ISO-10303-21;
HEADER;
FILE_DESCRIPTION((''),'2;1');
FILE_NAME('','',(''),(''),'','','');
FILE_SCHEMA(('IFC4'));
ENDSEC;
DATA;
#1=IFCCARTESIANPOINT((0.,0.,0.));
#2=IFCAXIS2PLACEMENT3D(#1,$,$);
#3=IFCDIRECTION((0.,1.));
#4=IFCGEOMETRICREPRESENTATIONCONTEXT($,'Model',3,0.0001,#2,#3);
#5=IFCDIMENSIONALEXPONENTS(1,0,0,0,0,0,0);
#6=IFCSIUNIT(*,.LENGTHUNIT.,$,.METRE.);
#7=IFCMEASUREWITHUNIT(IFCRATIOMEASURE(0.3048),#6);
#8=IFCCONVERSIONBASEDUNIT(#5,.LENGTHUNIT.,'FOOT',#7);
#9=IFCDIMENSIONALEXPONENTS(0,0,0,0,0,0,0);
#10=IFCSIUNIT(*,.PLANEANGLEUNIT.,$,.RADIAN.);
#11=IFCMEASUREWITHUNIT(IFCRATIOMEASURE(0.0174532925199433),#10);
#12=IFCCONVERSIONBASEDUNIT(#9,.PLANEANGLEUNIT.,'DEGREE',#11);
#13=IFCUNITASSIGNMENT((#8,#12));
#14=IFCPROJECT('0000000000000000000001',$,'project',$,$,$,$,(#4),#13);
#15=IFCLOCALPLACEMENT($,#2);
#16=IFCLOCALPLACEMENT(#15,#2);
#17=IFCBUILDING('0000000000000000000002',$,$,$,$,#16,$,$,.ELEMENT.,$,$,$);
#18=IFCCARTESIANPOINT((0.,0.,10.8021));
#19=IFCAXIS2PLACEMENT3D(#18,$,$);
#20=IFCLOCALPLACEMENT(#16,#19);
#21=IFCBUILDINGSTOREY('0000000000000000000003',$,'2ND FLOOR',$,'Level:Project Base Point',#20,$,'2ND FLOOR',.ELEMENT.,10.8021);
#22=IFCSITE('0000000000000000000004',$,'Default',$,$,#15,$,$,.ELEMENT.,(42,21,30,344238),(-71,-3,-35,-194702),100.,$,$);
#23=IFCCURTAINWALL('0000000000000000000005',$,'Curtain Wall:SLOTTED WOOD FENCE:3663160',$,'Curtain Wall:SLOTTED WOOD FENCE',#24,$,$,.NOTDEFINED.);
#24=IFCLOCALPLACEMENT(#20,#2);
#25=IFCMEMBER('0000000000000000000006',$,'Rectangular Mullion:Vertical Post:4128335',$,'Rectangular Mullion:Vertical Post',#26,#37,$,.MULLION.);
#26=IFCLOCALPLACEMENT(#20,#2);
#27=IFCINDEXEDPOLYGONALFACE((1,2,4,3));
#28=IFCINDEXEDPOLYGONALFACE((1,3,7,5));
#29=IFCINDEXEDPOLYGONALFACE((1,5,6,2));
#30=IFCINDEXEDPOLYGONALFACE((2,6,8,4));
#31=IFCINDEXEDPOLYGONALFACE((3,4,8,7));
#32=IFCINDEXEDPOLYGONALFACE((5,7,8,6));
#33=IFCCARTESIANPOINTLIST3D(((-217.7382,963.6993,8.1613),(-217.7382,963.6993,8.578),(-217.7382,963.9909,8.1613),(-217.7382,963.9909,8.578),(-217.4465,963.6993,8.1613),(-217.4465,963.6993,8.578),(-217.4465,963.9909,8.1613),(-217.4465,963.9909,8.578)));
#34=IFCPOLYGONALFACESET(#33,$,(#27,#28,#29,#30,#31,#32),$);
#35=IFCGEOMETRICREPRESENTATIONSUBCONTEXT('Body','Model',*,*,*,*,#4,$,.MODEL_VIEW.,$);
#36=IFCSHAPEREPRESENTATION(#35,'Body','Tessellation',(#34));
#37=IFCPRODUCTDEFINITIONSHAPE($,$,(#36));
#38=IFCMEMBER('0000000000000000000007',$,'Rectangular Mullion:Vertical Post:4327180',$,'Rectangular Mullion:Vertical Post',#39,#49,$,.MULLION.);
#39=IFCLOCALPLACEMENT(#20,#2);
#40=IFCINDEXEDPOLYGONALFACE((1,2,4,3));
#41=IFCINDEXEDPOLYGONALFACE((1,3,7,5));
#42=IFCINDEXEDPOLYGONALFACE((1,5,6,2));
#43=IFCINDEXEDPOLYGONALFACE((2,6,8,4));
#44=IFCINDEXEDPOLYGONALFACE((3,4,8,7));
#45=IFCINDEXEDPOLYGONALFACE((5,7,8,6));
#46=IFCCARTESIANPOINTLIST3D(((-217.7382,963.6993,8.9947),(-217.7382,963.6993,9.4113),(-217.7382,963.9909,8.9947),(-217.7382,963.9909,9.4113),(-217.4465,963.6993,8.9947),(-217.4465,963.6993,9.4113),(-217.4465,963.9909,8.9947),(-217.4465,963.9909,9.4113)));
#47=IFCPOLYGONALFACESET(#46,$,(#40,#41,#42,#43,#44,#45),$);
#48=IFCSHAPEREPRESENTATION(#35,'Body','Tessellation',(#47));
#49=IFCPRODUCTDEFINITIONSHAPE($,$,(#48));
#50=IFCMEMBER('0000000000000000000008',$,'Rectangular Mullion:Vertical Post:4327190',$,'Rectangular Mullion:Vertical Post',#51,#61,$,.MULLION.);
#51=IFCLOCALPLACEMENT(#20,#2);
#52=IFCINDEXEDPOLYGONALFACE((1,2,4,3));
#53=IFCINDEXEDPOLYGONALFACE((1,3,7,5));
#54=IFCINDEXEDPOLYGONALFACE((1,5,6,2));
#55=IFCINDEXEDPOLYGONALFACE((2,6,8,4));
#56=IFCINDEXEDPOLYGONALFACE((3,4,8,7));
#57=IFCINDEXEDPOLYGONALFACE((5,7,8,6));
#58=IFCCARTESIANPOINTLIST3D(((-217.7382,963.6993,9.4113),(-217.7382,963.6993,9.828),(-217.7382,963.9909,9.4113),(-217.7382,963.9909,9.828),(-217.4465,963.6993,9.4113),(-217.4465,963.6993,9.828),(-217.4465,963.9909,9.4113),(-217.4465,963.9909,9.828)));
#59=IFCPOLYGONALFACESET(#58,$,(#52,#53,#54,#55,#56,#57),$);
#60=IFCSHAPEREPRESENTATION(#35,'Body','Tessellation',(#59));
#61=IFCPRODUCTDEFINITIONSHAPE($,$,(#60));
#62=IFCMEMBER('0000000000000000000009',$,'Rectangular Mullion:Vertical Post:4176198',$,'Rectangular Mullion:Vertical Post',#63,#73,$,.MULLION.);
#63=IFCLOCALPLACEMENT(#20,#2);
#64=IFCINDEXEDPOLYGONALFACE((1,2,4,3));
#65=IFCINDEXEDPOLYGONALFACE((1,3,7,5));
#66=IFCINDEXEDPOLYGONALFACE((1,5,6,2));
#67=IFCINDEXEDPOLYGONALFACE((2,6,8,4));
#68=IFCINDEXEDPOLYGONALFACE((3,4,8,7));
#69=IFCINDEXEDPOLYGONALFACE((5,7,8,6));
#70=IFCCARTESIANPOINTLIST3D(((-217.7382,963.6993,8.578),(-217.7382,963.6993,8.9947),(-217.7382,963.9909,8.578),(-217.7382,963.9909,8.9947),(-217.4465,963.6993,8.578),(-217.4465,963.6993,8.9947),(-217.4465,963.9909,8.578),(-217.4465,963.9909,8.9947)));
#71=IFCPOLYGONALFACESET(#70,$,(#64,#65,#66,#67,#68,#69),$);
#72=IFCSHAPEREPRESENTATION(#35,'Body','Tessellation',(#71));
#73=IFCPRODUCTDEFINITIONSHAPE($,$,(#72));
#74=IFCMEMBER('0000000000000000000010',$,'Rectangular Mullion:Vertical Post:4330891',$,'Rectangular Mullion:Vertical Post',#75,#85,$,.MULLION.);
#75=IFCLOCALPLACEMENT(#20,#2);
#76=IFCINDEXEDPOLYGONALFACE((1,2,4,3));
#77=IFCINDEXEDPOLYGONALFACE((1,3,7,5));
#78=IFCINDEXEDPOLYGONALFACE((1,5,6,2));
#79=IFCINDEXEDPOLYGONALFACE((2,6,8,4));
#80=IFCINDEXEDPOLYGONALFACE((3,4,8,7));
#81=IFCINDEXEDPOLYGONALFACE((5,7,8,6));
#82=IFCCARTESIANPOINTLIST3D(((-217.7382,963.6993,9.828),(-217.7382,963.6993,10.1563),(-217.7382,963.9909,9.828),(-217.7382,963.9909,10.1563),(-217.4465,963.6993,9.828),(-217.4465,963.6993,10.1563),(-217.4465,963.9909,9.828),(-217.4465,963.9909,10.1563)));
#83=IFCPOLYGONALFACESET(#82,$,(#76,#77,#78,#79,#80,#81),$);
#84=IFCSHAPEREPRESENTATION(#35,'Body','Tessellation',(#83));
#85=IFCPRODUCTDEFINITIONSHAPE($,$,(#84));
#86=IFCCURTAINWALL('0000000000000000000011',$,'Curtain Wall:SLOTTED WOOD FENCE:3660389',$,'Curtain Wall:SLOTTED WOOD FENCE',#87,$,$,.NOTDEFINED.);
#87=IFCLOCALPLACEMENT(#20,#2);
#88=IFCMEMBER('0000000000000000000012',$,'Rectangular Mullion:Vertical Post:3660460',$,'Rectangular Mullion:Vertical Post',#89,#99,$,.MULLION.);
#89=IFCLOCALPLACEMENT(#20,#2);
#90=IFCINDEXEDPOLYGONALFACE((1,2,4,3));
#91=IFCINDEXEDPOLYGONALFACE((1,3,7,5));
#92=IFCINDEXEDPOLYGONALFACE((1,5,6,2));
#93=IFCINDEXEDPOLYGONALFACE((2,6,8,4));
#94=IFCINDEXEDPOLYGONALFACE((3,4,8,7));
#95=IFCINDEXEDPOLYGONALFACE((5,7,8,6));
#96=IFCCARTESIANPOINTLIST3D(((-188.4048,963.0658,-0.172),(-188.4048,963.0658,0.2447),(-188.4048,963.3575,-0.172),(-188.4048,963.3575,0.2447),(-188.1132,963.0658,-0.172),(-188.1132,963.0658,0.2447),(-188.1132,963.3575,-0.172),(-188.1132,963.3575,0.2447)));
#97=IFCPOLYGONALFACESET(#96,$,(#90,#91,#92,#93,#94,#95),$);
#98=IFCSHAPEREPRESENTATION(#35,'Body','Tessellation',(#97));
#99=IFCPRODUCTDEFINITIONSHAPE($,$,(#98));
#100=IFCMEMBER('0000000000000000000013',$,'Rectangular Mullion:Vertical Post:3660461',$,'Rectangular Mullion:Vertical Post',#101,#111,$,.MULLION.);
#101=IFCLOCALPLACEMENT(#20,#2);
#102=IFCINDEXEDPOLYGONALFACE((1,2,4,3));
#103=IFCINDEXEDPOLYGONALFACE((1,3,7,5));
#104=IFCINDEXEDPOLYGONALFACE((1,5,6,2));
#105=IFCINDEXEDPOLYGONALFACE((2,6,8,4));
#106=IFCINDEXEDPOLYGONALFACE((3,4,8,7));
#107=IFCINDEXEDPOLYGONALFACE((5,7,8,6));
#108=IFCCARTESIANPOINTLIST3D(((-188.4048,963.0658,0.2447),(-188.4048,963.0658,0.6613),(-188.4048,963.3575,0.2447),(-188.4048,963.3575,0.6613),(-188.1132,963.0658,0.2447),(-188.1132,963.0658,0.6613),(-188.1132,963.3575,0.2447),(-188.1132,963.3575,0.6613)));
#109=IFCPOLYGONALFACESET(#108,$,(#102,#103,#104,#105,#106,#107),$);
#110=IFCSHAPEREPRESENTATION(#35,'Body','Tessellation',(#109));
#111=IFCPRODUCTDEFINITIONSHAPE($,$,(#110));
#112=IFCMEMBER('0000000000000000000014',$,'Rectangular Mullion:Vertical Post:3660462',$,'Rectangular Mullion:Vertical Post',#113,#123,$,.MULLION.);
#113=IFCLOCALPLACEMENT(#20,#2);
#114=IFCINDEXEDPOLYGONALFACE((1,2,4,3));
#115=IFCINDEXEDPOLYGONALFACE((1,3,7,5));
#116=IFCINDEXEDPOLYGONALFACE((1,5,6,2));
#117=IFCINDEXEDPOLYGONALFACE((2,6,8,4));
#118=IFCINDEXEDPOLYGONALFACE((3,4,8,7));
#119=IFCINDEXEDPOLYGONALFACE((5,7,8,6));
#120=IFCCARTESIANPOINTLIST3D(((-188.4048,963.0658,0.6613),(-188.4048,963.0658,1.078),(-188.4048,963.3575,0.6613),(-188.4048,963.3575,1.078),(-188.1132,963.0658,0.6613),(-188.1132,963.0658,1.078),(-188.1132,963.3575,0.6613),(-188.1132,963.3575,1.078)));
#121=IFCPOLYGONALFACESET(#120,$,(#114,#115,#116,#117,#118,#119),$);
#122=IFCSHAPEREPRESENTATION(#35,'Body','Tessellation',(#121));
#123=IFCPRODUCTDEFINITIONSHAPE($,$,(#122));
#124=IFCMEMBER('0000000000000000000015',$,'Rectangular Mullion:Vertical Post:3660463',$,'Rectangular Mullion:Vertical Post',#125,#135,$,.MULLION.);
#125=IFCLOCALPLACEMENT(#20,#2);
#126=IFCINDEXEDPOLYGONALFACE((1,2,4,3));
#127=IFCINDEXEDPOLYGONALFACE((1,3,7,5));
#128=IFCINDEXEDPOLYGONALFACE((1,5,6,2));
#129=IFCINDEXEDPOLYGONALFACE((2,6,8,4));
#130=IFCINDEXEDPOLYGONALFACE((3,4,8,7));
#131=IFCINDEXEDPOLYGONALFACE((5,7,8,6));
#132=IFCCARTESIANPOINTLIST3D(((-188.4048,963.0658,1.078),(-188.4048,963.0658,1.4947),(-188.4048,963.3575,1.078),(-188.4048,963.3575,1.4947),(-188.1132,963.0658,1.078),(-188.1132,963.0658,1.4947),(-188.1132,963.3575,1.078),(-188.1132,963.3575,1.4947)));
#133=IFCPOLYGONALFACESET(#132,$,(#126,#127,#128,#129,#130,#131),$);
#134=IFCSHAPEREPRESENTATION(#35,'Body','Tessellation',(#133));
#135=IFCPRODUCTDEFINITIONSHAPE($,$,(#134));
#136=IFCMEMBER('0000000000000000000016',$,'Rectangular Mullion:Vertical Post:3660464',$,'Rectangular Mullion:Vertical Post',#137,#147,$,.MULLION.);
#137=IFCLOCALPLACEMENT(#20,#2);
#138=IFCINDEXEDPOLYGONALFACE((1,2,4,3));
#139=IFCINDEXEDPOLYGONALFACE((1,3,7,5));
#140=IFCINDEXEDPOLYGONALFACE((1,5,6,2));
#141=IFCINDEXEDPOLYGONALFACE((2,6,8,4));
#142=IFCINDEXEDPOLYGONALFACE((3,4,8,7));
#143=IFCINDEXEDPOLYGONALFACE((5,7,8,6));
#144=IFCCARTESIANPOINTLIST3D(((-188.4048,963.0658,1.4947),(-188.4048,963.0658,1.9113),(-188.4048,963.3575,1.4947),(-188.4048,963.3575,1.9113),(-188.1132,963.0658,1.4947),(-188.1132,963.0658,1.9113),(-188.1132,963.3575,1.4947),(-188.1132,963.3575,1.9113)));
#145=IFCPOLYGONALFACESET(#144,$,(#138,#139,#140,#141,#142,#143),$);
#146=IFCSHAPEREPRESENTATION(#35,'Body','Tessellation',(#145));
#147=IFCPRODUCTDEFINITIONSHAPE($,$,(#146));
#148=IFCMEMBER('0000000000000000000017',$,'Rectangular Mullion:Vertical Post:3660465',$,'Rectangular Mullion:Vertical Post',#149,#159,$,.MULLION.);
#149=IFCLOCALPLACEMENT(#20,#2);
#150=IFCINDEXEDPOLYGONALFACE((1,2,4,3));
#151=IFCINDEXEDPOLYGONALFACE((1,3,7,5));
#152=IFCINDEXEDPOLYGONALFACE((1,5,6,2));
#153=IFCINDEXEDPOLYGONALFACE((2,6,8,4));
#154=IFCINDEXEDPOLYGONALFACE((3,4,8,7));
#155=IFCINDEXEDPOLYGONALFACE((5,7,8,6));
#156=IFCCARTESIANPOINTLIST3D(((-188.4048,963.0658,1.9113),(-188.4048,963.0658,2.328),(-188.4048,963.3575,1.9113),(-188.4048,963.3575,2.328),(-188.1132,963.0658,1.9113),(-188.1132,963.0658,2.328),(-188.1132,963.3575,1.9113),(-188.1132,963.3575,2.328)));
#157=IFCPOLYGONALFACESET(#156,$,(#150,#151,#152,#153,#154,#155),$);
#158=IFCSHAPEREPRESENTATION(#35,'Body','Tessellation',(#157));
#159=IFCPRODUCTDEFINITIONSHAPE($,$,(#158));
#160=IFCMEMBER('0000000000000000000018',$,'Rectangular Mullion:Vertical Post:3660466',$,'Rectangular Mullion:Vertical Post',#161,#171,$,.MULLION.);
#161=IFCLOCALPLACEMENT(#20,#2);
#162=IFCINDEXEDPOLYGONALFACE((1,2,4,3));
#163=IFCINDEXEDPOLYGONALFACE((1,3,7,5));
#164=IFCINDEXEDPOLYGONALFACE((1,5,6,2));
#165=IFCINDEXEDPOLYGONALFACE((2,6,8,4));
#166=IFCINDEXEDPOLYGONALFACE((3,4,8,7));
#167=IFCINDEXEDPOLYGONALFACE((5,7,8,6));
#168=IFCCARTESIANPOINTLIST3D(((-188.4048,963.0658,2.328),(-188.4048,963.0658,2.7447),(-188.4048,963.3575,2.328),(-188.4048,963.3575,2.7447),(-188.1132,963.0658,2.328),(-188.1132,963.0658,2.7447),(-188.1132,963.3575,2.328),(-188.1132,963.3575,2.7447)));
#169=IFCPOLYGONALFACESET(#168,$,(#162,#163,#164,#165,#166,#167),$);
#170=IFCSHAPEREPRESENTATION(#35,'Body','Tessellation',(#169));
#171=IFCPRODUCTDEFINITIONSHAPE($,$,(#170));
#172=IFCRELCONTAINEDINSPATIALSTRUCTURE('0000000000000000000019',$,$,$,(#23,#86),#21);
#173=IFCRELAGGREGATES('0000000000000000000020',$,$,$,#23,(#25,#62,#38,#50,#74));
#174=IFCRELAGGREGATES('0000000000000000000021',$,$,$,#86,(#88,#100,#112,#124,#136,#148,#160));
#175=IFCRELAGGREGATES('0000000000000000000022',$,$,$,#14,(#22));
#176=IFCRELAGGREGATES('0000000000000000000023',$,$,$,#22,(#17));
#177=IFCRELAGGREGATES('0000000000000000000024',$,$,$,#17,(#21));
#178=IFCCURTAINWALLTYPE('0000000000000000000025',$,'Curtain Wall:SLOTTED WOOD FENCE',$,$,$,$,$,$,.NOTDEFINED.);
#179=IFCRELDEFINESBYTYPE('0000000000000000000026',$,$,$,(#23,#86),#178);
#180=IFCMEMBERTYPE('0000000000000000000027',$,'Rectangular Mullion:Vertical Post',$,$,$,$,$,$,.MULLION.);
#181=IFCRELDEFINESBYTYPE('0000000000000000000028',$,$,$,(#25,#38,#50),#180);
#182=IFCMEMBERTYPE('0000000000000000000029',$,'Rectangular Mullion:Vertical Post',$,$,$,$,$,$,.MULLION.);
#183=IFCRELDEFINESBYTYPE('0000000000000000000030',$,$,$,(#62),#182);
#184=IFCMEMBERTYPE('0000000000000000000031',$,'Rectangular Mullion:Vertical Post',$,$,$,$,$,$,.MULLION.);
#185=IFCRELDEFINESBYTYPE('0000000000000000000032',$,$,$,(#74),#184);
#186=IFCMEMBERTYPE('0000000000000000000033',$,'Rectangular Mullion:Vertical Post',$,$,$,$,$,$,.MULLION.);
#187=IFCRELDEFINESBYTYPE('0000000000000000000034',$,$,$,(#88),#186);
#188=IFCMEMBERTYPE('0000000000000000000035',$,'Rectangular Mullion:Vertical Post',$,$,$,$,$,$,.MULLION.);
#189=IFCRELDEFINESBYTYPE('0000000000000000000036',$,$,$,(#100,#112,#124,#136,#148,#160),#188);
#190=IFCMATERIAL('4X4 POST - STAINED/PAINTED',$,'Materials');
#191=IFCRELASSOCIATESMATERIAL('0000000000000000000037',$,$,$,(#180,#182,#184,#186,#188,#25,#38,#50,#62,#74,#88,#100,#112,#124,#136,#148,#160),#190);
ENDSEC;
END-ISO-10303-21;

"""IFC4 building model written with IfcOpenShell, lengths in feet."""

from ifc_helpers import new_model, entity, si_unit, converted_unit, direction, frame, origin, origin_2d_with_axis, place, context, subcontext, project, spatial, rectangle, extrude, source, transform, mapped, material, material_profile, profile_set, profile_usage, type_object, type_shapes, element, aggregate, save


model = new_model("IFC4")

# Units and contexts
model_context = context("Model", 3, precision=0.0001, world=origin(), true_north=direction((0.0, 1.0)))
body_context = subcontext(model_context, "Body", "Model", "MODEL_VIEW")
ifc_project = project(units=[converted_unit("LENGTHUNIT", "FOOT", entity("IfcRatioMeasure", 0.3048), si_unit("LENGTHUNIT", "METRE"), dimensions=[1, 0, 0, 0, 0, 0, 0]), converted_unit("PLANEANGLEUNIT", "DEGREE", entity("IfcRatioMeasure", 0.0174532925199433), si_unit("PLANEANGLEUNIT", "RADIAN"), dimensions=[0, 0, 0, 0, 0, 0, 0])], contexts=[model_context])

# Site, building, storey
site_placement = place(None, origin())
site = spatial("IfcSite", under=ifc_project, at=site_placement, Name="Default", CompositionType="ELEMENT", RefLatitude=(42, 21, 30, 344238), RefLongitude=(-71, -3, -35, -194702), RefElevation=100.0)
building_placement = place(site_placement, origin())
building = spatial("IfcBuilding", under=site, at=building_placement, CompositionType="ELEMENT")
storey_placement = place(building_placement, frame((0.0, 0.0, 10.8021)))
storey = spatial("IfcBuildingStorey", under=building, at=storey_placement, Name="2ND FLOOR", ObjectType="Level:Project Base Point", LongName="2ND FLOOR", CompositionType="ELEMENT", Elevation=10.8021)

# Curtain walls, members
curtain_wall_type = type_object("IfcCurtainWallType", Name="Curtain Wall:SLOTTED WOOD FENCE", PredefinedType="NOTDEFINED")
curtain_wall_1_placement = place(storey_placement, frame((0.0, 0.0, -10.8021)))
curtain_wall_1 = element("IfcCurtainWall", 1, at=curtain_wall_1_placement, inside=storey, type_object=curtain_wall_type, Name="Curtain Wall:SLOTTED WOOD FENCE:3663160", ObjectType="Curtain Wall:SLOTTED WOOD FENCE", PredefinedType="NOTDEFINED")
ifc_material_1 = material(Name="4X4 POST - STAINED/PAINTED", Category="Materials")
ifc_material_profile = material_profile(ifc_material_1, rectangle(XDim=0.2917, YDim=0.2917, at=origin_2d_with_axis()), Name="Vertical Post")
ifc_profile_set = profile_set([ifc_material_profile], Name="Vertical Post")
member_type_1 = type_object("IfcMemberType", Name="Rectangular Mullion:Vertical Post", PredefinedType="MULLION", material=ifc_profile_set)
shared_shape_1 = source(origin(), body_context, "Body", "SweptSolid", [
    extrude(rectangle(XDim=0.2917, YDim=0.2917, at=origin_2d_with_axis()), frame((0.0, -0.2083, -0.4167), z_axis=(0.0, 0.0, 1.0), x_axis=(0.0, -1.0, 0.0)), (0.0, 0.0, 1.0), 0.4167),
])
type_shapes(member_type_1, [shared_shape_1])
ifc_profile_usage_1 = profile_usage(ifc_profile_set)
member_1_placement = place(storey_placement, frame((-217.8007, 963.8451, 8.1613), z_axis=(0.0, 0.0, -1.0), x_axis=(0.0, -1.0, 0.0)))
member_1 = element("IfcMember", 2, at=member_1_placement, type_object=member_type_1, material=ifc_profile_usage_1, Name="Rectangular Mullion:Vertical Post:4128335", ObjectType="Rectangular Mullion:Vertical Post", PredefinedType="MULLION", context=body_context, shape_type="MappedRepresentation", body=[
    mapped(shared_shape_1, transform((0.0, 0.0, 0.0), scale=1.0)),
])
ifc_profile_usage_2 = profile_usage(ifc_profile_set)
member_2_placement = place(storey_placement, frame((-217.8007, 963.8451, 8.9947), z_axis=(0.0, 0.0, -1.0), x_axis=(0.0, -1.0, 0.0)))
member_2 = element("IfcMember", 3, at=member_2_placement, type_object=member_type_1, material=ifc_profile_usage_2, Name="Rectangular Mullion:Vertical Post:4327180", ObjectType="Rectangular Mullion:Vertical Post", PredefinedType="MULLION", context=body_context, shape_type="MappedRepresentation", body=[
    mapped(shared_shape_1, transform((0.0, 0.0, 0.0), scale=1.0)),
])
ifc_profile_usage_3 = profile_usage(ifc_profile_set)
member_3_placement = place(storey_placement, frame((-217.8007, 963.8451, 9.4113), z_axis=(0.0, 0.0, -1.0), x_axis=(0.0, -1.0, 0.0)))
member_3 = element("IfcMember", 4, at=member_3_placement, type_object=member_type_1, material=ifc_profile_usage_3, Name="Rectangular Mullion:Vertical Post:4327190", ObjectType="Rectangular Mullion:Vertical Post", PredefinedType="MULLION", context=body_context, shape_type="MappedRepresentation", body=[
    mapped(shared_shape_1, transform((0.0, 0.0, 0.0), scale=1.0)),
])
ifc_profile_usage_4 = profile_usage(ifc_profile_set)
member_type_2 = type_object("IfcMemberType", Name="Rectangular Mullion:Vertical Post", PredefinedType="MULLION", material=ifc_profile_set)
shared_shape_2 = source(origin(), body_context, "Body", "SweptSolid", [
    extrude(rectangle(XDim=0.2917, YDim=0.2917, at=origin_2d_with_axis()), frame((0.0, -0.2083, -0.4167), z_axis=(0.0, 0.0, 1.0), x_axis=(0.0, -1.0, 0.0)), (0.0, 0.0, 1.0), 0.4167),
])
type_shapes(member_type_2, [shared_shape_2])
member_4_placement = place(storey_placement, frame((-217.8007, 963.8451, 8.578), z_axis=(0.0, 0.0, -1.0), x_axis=(0.0, -1.0, 0.0)))
member_4 = element("IfcMember", 5, at=member_4_placement, type_object=member_type_2, material=ifc_profile_usage_4, Name="Rectangular Mullion:Vertical Post:4176198", ObjectType="Rectangular Mullion:Vertical Post", PredefinedType="MULLION", context=body_context, shape_type="MappedRepresentation", body=[
    mapped(shared_shape_2, transform((0.0, 0.0, 0.0), scale=1.0)),
])
ifc_profile_usage_5 = profile_usage(ifc_profile_set)
member_type_3 = type_object("IfcMemberType", Name="Rectangular Mullion:Vertical Post", PredefinedType="MULLION", material=ifc_profile_set)
shared_shape_3 = source(origin(), body_context, "Body", "SweptSolid", [
    extrude(rectangle(XDim=0.2917, YDim=0.2917, at=origin_2d_with_axis()), frame((0.0, -0.2083, -0.3282), z_axis=(0.0, 0.0, 1.0), x_axis=(0.0, -1.0, 0.0)), (0.0, 0.0, 1.0), 0.3282),
])
type_shapes(member_type_3, [shared_shape_3])
member_5_placement = place(storey_placement, frame((-217.8007, 963.8451, 9.828), z_axis=(0.0, 0.0, -1.0), x_axis=(0.0, -1.0, 0.0)))
member_5 = element("IfcMember", 6, at=member_5_placement, type_object=member_type_3, material=ifc_profile_usage_5, Name="Rectangular Mullion:Vertical Post:4330891", ObjectType="Rectangular Mullion:Vertical Post", PredefinedType="MULLION", context=body_context, shape_type="MappedRepresentation", body=[
    mapped(shared_shape_3, transform((0.0, 0.0, 0.0), scale=1.0)),
])
aggregate(curtain_wall_1, [member_1, member_4, member_2, member_3, member_5])
curtain_wall_2_placement = place(storey_placement, frame((0.0, 0.0, -10.8021)))
curtain_wall_2 = element("IfcCurtainWall", 7, at=curtain_wall_2_placement, inside=storey, type_object=curtain_wall_type, Name="Curtain Wall:SLOTTED WOOD FENCE:3660389", ObjectType="Curtain Wall:SLOTTED WOOD FENCE", PredefinedType="NOTDEFINED")
ifc_profile_usage_6 = profile_usage(ifc_profile_set)
member_type_4 = type_object("IfcMemberType", Name="Rectangular Mullion:Vertical Post", PredefinedType="MULLION", material=ifc_profile_set)
shared_shape_4 = source(origin(), body_context, "Body", "SweptSolid", [
    extrude(rectangle(XDim=0.2917, YDim=0.2917, at=origin_2d_with_axis()), frame((-0.1458, 0.2083, -0.4167), z_axis=(0.0, 0.0, 1.0), x_axis=(0.0, -1.0, 0.0)), (0.0, 0.0, 1.0), 0.4167),
])
type_shapes(member_type_4, [shared_shape_4])
member_6_placement = place(storey_placement, frame((-188.0507, 963.0658, -0.172), z_axis=(0.0, 0.0, -1.0), x_axis=(0.0, -1.0, 0.0)))
member_6 = element("IfcMember", 8, at=member_6_placement, type_object=member_type_4, material=ifc_profile_usage_6, Name="Rectangular Mullion:Vertical Post:3660460", ObjectType="Rectangular Mullion:Vertical Post", PredefinedType="MULLION", context=body_context, shape_type="MappedRepresentation", body=[
    mapped(shared_shape_4, transform((0.0, 0.0, 0.0), scale=1.0)),
])
ifc_profile_usage_7 = profile_usage(ifc_profile_set)
member_type_5 = type_object("IfcMemberType", Name="Rectangular Mullion:Vertical Post", PredefinedType="MULLION", material=ifc_profile_set)
shared_shape_5 = source(origin(), body_context, "Body", "SweptSolid", [
    extrude(rectangle(XDim=0.2917, YDim=0.2917, at=origin_2d_with_axis()), frame((-0.1458, 0.2083, -0.4167), z_axis=(0.0, 0.0, 1.0), x_axis=(0.0, -1.0, 0.0)), (0.0, 0.0, 1.0), 0.4167),
])
type_shapes(member_type_5, [shared_shape_5])
member_7_placement = place(storey_placement, frame((-188.0507, 963.0658, 0.2447), z_axis=(0.0, 0.0, -1.0), x_axis=(0.0, -1.0, 0.0)))
member_7 = element("IfcMember", 9, at=member_7_placement, type_object=member_type_5, material=ifc_profile_usage_7, Name="Rectangular Mullion:Vertical Post:3660461", ObjectType="Rectangular Mullion:Vertical Post", PredefinedType="MULLION", context=body_context, shape_type="MappedRepresentation", body=[
    mapped(shared_shape_5, transform((0.0, 0.0, 0.0), scale=1.0)),
])
ifc_profile_usage_8 = profile_usage(ifc_profile_set)
member_8_placement = place(storey_placement, frame((-188.0507, 963.0658, 0.6613), z_axis=(0.0, 0.0, -1.0), x_axis=(0.0, -1.0, 0.0)))
member_8 = element("IfcMember", 10, at=member_8_placement, type_object=member_type_5, material=ifc_profile_usage_8, Name="Rectangular Mullion:Vertical Post:3660462", ObjectType="Rectangular Mullion:Vertical Post", PredefinedType="MULLION", context=body_context, shape_type="MappedRepresentation", body=[
    mapped(shared_shape_5, transform((0.0, 0.0, 0.0), scale=1.0)),
])
ifc_profile_usage_9 = profile_usage(ifc_profile_set)
member_9_placement = place(storey_placement, frame((-188.0507, 963.0658, 1.078), z_axis=(0.0, 0.0, -1.0), x_axis=(0.0, -1.0, 0.0)))
member_9 = element("IfcMember", 11, at=member_9_placement, type_object=member_type_5, material=ifc_profile_usage_9, Name="Rectangular Mullion:Vertical Post:3660463", ObjectType="Rectangular Mullion:Vertical Post", PredefinedType="MULLION", context=body_context, shape_type="MappedRepresentation", body=[
    mapped(shared_shape_5, transform((0.0, 0.0, 0.0), scale=1.0)),
])
ifc_profile_usage_10 = profile_usage(ifc_profile_set)
member_10_placement = place(storey_placement, frame((-188.0507, 963.0658, 1.4947), z_axis=(0.0, 0.0, -1.0), x_axis=(0.0, -1.0, 0.0)))
member_10 = element("IfcMember", 12, at=member_10_placement, type_object=member_type_5, material=ifc_profile_usage_10, Name="Rectangular Mullion:Vertical Post:3660464", ObjectType="Rectangular Mullion:Vertical Post", PredefinedType="MULLION", context=body_context, shape_type="MappedRepresentation", body=[
    mapped(shared_shape_5, transform((0.0, 0.0, 0.0), scale=1.0)),
])
ifc_profile_usage_11 = profile_usage(ifc_profile_set)
member_11_placement = place(storey_placement, frame((-188.0507, 963.0658, 1.9113), z_axis=(0.0, 0.0, -1.0), x_axis=(0.0, -1.0, 0.0)))
member_11 = element("IfcMember", 13, at=member_11_placement, type_object=member_type_5, material=ifc_profile_usage_11, Name="Rectangular Mullion:Vertical Post:3660465", ObjectType="Rectangular Mullion:Vertical Post", PredefinedType="MULLION", context=body_context, shape_type="MappedRepresentation", body=[
    mapped(shared_shape_5, transform((0.0, 0.0, 0.0), scale=1.0)),
])
ifc_profile_usage_12 = profile_usage(ifc_profile_set)
member_12_placement = place(storey_placement, frame((-188.0507, 963.0658, 2.328), z_axis=(0.0, 0.0, -1.0), x_axis=(0.0, -1.0, 0.0)))
member_12 = element("IfcMember", 14, at=member_12_placement, type_object=member_type_5, material=ifc_profile_usage_12, Name="Rectangular Mullion:Vertical Post:3660466", ObjectType="Rectangular Mullion:Vertical Post", PredefinedType="MULLION", context=body_context, shape_type="MappedRepresentation", body=[
    mapped(shared_shape_5, transform((0.0, 0.0, 0.0), scale=1.0)),
])
aggregate(curtain_wall_2, [member_6, member_7, member_8, member_9, member_10, member_11, member_12])

save(model, "model.ifc")
